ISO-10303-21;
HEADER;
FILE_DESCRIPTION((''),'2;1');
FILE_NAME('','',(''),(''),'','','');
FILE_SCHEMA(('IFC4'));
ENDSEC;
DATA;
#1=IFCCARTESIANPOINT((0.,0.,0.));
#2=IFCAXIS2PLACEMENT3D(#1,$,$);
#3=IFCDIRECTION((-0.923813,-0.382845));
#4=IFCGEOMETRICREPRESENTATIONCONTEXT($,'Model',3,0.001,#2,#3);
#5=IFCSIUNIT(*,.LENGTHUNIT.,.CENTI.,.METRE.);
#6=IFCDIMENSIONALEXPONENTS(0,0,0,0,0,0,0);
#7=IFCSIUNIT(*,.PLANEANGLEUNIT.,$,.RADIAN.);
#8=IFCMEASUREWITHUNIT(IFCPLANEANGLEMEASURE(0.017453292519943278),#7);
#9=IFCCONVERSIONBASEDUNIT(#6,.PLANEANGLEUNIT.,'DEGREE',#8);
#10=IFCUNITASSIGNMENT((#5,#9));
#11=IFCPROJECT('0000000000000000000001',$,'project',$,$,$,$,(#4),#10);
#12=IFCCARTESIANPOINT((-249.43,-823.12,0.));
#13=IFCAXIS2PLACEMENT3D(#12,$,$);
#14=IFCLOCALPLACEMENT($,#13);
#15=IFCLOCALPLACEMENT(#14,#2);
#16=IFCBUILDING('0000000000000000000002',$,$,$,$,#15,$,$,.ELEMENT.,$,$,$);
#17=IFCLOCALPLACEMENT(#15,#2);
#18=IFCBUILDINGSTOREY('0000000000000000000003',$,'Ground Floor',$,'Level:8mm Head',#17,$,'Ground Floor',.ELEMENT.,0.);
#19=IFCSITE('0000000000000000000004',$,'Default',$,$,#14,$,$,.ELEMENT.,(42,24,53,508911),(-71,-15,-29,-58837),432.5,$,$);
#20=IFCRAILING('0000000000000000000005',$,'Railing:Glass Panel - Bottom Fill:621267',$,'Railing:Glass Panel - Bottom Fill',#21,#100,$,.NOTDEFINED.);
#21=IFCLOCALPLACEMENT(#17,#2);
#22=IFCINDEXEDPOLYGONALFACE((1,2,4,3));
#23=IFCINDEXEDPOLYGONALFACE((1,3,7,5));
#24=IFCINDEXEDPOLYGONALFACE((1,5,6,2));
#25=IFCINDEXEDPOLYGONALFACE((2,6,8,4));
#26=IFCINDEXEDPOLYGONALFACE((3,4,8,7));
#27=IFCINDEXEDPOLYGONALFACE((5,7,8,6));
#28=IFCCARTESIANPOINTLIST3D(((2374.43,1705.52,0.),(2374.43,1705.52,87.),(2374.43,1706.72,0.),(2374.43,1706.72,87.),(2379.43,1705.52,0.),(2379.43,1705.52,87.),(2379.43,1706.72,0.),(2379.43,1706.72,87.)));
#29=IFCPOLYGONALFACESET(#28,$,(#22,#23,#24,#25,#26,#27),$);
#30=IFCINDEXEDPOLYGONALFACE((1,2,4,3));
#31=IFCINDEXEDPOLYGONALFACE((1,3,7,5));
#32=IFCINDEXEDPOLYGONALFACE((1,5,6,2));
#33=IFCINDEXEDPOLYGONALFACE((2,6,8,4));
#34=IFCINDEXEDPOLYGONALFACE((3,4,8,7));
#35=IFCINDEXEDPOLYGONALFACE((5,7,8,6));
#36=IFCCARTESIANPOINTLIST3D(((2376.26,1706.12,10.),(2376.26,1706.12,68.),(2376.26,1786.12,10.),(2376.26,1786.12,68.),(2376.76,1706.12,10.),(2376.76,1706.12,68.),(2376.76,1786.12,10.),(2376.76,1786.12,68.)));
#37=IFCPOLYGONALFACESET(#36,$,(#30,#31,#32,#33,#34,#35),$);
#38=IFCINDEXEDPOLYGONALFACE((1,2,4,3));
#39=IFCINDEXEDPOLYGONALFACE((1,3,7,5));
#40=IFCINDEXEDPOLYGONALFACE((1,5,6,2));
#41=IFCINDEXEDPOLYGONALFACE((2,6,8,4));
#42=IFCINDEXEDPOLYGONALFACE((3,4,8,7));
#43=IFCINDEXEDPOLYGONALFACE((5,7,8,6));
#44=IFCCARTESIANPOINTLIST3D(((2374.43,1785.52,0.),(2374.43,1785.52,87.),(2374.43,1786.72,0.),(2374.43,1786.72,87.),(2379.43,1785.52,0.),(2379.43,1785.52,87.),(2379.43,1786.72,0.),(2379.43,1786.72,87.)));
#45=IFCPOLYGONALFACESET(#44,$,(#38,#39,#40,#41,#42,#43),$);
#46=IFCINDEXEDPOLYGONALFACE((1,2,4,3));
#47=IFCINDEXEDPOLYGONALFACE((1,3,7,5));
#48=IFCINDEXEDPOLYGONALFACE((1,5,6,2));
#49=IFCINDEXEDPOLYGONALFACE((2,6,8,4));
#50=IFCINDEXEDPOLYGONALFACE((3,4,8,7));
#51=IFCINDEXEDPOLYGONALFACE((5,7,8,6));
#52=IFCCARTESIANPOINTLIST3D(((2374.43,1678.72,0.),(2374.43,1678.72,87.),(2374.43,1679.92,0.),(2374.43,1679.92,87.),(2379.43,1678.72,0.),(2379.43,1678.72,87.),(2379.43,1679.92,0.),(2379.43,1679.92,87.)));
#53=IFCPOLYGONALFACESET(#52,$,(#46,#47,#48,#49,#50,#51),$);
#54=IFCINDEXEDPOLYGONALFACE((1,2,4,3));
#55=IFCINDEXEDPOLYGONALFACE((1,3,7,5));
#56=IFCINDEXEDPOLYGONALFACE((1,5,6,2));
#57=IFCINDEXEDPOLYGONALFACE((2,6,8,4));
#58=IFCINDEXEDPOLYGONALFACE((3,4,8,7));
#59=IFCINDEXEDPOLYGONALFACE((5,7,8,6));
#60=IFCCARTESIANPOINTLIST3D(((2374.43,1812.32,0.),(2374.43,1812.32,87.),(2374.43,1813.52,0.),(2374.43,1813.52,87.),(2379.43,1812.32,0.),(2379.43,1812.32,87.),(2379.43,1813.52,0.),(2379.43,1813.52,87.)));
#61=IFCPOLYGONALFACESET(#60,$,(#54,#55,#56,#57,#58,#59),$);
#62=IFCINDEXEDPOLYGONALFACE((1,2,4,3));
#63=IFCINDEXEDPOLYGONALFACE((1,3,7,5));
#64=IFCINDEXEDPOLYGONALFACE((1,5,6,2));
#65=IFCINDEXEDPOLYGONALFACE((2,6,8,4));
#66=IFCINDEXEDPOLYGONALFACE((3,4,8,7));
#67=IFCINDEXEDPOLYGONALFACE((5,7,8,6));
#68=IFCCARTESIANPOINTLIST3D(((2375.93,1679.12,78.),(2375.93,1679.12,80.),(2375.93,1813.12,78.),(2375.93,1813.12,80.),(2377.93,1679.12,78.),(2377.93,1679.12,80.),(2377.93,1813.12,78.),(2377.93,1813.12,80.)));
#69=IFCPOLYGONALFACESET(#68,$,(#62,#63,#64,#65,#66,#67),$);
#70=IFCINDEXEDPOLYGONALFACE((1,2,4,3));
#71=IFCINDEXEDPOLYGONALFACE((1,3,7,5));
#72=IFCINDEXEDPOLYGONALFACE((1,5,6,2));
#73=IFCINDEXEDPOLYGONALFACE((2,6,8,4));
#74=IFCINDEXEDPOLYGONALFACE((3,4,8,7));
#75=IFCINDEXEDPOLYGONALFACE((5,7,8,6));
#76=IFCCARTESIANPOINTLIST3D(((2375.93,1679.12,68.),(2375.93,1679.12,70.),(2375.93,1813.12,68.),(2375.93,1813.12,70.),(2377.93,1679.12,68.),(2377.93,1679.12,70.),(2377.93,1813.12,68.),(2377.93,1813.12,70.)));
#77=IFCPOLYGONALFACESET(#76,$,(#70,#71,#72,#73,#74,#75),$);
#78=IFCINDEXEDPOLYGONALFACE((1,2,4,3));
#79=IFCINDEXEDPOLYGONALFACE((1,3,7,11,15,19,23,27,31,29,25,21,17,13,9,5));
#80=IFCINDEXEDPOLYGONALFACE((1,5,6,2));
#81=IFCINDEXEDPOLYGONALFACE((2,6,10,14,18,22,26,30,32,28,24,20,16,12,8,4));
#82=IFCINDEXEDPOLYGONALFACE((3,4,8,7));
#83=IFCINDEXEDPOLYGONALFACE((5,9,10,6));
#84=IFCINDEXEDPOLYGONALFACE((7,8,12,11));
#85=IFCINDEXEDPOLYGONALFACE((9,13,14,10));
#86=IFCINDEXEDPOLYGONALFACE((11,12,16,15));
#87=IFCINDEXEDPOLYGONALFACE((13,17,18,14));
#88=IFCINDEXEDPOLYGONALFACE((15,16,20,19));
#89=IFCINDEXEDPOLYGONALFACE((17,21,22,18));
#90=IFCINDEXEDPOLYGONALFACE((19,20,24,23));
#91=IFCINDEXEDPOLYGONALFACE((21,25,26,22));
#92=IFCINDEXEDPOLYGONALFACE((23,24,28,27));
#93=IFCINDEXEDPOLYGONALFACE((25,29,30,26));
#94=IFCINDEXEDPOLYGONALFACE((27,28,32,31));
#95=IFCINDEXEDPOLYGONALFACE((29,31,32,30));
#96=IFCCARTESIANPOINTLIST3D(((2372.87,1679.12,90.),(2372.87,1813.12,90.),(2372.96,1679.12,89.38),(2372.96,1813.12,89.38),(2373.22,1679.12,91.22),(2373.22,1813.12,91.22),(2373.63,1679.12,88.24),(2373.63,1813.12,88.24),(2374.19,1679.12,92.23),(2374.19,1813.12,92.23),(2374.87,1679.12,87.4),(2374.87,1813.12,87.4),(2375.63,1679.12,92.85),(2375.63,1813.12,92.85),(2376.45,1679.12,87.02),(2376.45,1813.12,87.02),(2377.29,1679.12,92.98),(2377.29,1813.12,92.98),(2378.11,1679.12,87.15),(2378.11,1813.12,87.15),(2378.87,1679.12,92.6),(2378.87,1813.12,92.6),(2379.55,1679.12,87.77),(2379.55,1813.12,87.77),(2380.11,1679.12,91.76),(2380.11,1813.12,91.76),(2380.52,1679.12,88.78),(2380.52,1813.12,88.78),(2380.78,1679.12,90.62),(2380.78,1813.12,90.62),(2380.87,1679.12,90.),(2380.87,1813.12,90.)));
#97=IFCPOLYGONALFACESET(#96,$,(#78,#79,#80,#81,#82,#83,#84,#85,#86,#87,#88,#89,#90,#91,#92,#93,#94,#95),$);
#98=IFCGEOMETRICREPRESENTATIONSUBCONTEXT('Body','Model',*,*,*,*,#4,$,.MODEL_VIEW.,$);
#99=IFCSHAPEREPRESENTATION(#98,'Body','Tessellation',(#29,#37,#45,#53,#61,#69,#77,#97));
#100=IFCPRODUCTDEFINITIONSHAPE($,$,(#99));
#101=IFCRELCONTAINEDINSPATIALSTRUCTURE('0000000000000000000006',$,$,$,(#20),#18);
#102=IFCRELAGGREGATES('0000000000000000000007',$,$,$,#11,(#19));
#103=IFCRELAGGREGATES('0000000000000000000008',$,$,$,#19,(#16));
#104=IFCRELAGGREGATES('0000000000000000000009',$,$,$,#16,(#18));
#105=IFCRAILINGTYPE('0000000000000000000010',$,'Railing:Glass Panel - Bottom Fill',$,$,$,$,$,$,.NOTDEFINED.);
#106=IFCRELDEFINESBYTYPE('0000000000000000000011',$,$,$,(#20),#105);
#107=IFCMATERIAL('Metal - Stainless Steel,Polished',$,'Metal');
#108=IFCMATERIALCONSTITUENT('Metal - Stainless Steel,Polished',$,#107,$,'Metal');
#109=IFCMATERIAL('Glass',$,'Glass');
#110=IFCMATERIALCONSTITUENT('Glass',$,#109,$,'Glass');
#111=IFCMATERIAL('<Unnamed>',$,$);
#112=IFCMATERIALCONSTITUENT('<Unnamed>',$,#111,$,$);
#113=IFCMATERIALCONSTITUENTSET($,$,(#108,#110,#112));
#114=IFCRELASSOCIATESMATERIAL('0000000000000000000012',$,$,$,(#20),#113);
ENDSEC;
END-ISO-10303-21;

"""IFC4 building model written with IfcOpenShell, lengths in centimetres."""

from ifc_helpers import new_model, entity, si_unit, converted_unit, direction, frame, origin, place, context, subcontext, project, spatial, indexed_curve, outline, extrude, material, constituent, constituent_set, type_object, element, save


model = new_model("IFC4")

# Units and contexts
model_context = context("Model", 3, precision=0.001, world=origin(), true_north=direction((-0.923813, -0.382845)))
body_context = subcontext(model_context, "Body", "Model", "MODEL_VIEW")
ifc_project = project(units=[si_unit("LENGTHUNIT", "METRE", prefix="CENTI"), converted_unit("PLANEANGLEUNIT", "DEGREE", entity("IfcPlaneAngleMeasure", 0.017453292519943278), si_unit("PLANEANGLEUNIT", "RADIAN"), dimensions=[0, 0, 0, 0, 0, 0, 0])], contexts=[model_context])

# Site, building, storey
site_placement = place(None, frame((-249.43, -823.12, 0.0)))
site = spatial("IfcSite", under=ifc_project, at=site_placement, Name="Default", CompositionType="ELEMENT", RefLatitude=(42, 24, 53, 508911), RefLongitude=(-71, -15, -29, -58837), RefElevation=432.5)
building_placement = place(site_placement, origin())
building = spatial("IfcBuilding", under=site, at=building_placement, CompositionType="ELEMENT")
storey_placement = place(building_placement, origin())
storey = spatial("IfcBuildingStorey", under=building, at=storey_placement, Name="Ground Floor", ObjectType="Level:8mm Head", LongName="Ground Floor", CompositionType="ELEMENT", Elevation=0.0)

# Shared definitions
ifc_material_1 = material(Name="Glass", Category="Glass")

# Railing
ifc_material_2 = material(Name="Metal - Stainless Steel,Polished", Category="Metal")
ifc_constituent_1 = constituent(ifc_material_2, Name="Metal - Stainless Steel,Polished", Category="Metal")
ifc_constituent_2 = constituent(ifc_material_1, Name="Glass", Category="Glass")
ifc_material_3 = material(Name="<Unnamed>")
ifc_constituent_3 = constituent(ifc_material_3, Name="<Unnamed>")
ifc_constituent_set_1 = constituent_set(constituents=[ifc_constituent_1, ifc_constituent_2, ifc_constituent_3])
railing_type = type_object("IfcRailingType", Name="Railing:Glass Panel - Bottom Fill", PredefinedType="NOTDEFINED")
railing_1_placement = place(storey_placement, origin())
element("IfcRailing", 1, at=railing_1_placement, inside=storey, type_object=railing_type, material=ifc_constituent_set_1, Name="Railing:Glass Panel - Bottom Fill:621267", ObjectType="Railing:Glass Panel - Bottom Fill", PredefinedType="NOTDEFINED", context=body_context, shape_type="SweptSolid", body=[
    extrude(outline(indexed_curve([(-2.5, -0.6), (2.5, -0.6), (2.5, 0.6), (-2.5, 0.6), (-2.5, -0.6)], self_intersect=False)), frame((2376.93, 1706.12, 0.0), z_axis=(0.0, 0.0, 1.0), x_axis=(-1.0, 0.0, 0.0)), (0.0, 0.0, 1.0), 87.0),
    extrude(outline(indexed_curve([(-0.25, -40.0), (0.25, -40.0), (0.25, 40.0), (-0.25, 40.0), (-0.25, -40.0)], self_intersect=False)), frame((2376.51, 1746.12, 10.0), z_axis=(0.0, 0.0, 1.0), x_axis=(-1.0, 0.0, 0.0)), (0.0, 0.0, 1.0), 58.0),
    extrude(outline(indexed_curve([(-2.5, -0.6), (2.5, -0.6), (2.5, 0.6), (-2.5, 0.6), (-2.5, -0.6)], self_intersect=False)), frame((2376.93, 1786.12, 0.0), z_axis=(0.0, 0.0, 1.0), x_axis=(-1.0, 0.0, 0.0)), (0.0, 0.0, 1.0), 87.0),
    extrude(outline(indexed_curve([(-2.5, -0.6), (2.5, -0.6), (2.5, 0.6), (-2.5, 0.6), (-2.5, -0.6)], self_intersect=False)), frame((2376.93, 1679.32, 0.0), z_axis=(0.0, 0.0, 1.0), x_axis=(-1.0, 0.0, 0.0)), (0.0, 0.0, 1.0), 87.0),
    extrude(outline(indexed_curve([(-2.5, -0.6), (2.5, -0.6), (2.5, 0.6), (-2.5, 0.6), (-2.5, -0.6)], self_intersect=False)), frame((2376.93, 1812.92, 0.0), z_axis=(0.0, 0.0, 1.0), x_axis=(-1.0, 0.0, 0.0)), (0.0, 0.0, 1.0), 87.0),
    extrude(outline(indexed_curve([(-67.0, -1.0), (67.0, -1.0), (67.0, 1.0), (-67.0, 1.0), (-67.0, -1.0)], self_intersect=False)), frame((2376.93, 1746.12, 78.0), z_axis=(0.0, 0.0, 1.0), x_axis=(0.0, -1.0, 0.0)), (0.0, 0.0, 1.0), 2.0),
    extrude(outline(indexed_curve([(-67.0, -1.0), (67.0, -1.0), (67.0, 1.0), (-67.0, 1.0), (-67.0, -1.0)], self_intersect=False)), frame((2376.93, 1746.12, 68.0), z_axis=(0.0, 0.0, 1.0), x_axis=(0.0, -1.0, 0.0)), (0.0, 0.0, 1.0), 2.0),
    extrude(outline(indexed_curve([(-1.09, -3.85), (0.18, -3.85), (1.42, -3.18), (2.41, -1.97), (2.98, -0.41), (3.04, 1.22), (2.58, 2.63), (1.67, 3.59), (1.09, 3.85), (-0.18, 3.85), (-1.42, 3.18), (-2.41, 1.97), (-2.98, 0.41), (-3.04, -1.22), (-2.58, -2.63), (-1.67, -3.59), (-1.09, -3.85)], self_intersect=False)), frame((2376.87, 1679.12, 90.0), z_axis=(0.0, 1.0, 0.0), x_axis=(-0.27267, 0.0, -0.962108)), (0.0, 0.0, 1.0), 134.0),
])

save(model, "model.ifc")
